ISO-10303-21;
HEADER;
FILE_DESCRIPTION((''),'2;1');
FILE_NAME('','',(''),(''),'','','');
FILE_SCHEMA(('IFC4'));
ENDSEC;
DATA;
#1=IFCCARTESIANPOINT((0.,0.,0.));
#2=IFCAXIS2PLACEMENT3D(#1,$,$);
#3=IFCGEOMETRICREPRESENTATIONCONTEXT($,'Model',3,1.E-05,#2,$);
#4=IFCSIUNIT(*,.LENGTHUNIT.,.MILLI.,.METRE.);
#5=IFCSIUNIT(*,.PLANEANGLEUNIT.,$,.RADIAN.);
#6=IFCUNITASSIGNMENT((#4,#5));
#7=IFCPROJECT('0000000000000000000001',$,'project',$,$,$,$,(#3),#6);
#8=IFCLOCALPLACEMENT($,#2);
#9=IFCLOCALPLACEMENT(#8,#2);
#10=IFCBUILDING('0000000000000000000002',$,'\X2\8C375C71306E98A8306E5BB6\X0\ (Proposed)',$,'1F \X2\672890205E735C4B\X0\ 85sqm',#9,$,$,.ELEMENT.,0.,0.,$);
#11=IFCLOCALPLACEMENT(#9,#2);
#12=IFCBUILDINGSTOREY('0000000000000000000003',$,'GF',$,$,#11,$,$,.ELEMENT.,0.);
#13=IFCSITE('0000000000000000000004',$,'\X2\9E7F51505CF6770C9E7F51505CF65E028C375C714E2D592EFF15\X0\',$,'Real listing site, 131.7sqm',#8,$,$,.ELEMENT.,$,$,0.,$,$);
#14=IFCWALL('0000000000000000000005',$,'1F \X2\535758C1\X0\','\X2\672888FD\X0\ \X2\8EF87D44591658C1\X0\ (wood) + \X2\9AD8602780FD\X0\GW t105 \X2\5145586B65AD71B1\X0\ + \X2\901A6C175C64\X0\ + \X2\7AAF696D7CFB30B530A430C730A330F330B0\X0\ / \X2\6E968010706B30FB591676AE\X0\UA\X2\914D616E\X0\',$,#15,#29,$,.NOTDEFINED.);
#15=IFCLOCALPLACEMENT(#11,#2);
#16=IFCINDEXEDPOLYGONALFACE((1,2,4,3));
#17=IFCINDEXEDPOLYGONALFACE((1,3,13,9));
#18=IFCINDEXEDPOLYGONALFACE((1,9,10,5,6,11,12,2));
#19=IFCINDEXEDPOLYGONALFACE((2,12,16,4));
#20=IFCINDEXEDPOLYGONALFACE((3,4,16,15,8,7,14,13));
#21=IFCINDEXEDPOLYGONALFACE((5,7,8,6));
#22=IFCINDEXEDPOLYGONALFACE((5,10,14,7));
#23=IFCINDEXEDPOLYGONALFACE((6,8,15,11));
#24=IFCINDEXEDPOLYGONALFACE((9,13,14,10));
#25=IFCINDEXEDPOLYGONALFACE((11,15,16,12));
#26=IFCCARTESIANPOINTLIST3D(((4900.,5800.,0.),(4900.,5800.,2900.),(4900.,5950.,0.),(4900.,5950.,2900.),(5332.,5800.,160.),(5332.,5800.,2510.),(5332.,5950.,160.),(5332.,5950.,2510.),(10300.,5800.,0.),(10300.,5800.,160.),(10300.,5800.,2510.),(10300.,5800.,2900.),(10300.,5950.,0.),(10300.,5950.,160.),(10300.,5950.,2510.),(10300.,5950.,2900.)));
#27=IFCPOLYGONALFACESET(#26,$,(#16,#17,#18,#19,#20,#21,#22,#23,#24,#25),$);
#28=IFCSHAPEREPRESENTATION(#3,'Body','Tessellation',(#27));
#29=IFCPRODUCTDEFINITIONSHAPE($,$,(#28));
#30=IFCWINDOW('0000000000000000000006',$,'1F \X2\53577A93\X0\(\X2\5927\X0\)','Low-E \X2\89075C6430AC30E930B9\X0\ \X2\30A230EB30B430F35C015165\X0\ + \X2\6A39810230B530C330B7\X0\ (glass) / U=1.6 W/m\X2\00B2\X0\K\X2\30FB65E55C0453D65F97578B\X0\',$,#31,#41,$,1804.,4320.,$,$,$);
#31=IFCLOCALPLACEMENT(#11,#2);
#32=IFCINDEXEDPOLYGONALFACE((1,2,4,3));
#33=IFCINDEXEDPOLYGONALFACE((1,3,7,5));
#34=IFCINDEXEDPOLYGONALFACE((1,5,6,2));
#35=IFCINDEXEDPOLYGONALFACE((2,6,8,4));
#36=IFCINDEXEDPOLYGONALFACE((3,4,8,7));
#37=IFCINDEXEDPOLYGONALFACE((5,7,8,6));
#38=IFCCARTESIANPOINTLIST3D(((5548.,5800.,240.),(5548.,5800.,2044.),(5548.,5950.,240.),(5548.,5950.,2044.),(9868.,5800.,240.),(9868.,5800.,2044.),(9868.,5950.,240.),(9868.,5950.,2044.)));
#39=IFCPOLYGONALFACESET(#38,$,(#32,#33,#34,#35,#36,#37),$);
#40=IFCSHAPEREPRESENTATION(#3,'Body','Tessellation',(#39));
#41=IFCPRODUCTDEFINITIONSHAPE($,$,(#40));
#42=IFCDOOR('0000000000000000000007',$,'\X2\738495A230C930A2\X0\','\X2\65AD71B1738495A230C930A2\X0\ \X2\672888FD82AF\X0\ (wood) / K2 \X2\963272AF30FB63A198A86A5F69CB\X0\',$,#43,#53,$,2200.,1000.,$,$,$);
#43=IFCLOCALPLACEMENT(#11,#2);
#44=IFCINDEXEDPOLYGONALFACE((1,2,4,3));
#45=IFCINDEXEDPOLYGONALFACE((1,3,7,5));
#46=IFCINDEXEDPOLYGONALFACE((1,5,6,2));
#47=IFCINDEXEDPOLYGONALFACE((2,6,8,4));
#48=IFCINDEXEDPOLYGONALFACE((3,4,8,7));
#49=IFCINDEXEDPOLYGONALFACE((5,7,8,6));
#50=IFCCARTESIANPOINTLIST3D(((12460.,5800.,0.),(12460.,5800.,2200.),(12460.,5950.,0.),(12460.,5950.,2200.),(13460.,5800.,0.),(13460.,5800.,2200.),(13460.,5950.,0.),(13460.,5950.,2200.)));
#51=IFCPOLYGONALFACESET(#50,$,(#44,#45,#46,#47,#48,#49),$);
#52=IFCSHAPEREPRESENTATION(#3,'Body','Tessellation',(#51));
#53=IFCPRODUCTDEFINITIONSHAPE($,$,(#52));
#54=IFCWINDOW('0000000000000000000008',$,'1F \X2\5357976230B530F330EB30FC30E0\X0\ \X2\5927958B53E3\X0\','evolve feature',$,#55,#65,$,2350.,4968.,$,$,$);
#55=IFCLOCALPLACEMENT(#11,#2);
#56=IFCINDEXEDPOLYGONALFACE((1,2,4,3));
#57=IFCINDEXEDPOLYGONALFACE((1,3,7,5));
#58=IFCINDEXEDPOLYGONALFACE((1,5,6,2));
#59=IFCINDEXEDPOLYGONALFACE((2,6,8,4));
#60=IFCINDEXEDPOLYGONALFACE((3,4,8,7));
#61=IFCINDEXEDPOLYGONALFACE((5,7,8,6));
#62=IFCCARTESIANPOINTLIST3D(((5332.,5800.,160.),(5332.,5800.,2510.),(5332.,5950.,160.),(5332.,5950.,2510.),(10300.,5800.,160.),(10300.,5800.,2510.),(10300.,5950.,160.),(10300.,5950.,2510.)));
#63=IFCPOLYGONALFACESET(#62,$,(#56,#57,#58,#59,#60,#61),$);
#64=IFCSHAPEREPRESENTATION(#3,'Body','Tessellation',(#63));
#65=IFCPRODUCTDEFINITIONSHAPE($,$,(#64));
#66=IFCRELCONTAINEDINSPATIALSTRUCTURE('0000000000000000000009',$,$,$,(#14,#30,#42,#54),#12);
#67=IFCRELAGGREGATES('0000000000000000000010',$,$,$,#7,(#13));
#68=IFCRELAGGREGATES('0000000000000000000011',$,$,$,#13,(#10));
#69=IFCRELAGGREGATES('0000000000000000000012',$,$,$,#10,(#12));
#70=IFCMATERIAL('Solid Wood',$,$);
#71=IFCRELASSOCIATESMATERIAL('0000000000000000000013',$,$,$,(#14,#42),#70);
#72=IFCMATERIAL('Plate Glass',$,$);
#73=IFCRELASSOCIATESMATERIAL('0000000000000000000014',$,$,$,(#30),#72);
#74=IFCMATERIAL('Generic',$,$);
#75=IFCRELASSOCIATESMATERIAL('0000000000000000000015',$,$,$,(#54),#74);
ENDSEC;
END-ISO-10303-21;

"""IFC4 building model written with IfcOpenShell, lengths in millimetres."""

from ifc_helpers import new_model, si_unit, frame, frame_2d, origin, place, context, project, spatial, rectangle, extrude, material, element, fill, save


model = new_model("IFC4")

# Units and contexts
model_context = context("Model", 3, precision=1e-05, world=origin())
ifc_project = project(units=[si_unit("LENGTHUNIT", "METRE", prefix="MILLI"), si_unit("PLANEANGLEUNIT", "RADIAN")], contexts=[model_context])

# Site, building, storey
site_placement = place(None, origin())
site = spatial("IfcSite", under=ifc_project, at=site_placement, Name="鹿児島県鹿児島市谷山中央５", ObjectType="Real listing site, 131.7sqm", CompositionType="ELEMENT", RefElevation=0.0)
building_placement = place(site_placement, origin())
building = spatial("IfcBuilding", under=site, at=building_placement, Name="谷山の風の家 (Proposed)", ObjectType="1F 木造平屋 85sqm", CompositionType="ELEMENT", ElevationOfRefHeight=0.0, ElevationOfTerrain=0.0)
storey_placement = place(building_placement, origin())
storey = spatial("IfcBuildingStorey", under=building, at=storey_placement, Name="GF", CompositionType="ELEMENT", Elevation=0.0)

# Shared definitions
ifc_material_1 = material(Name="Solid Wood")
ifc_material_2 = material(Name="Generic")

# Wall, openings, windows, door
wall_1_placement = place(storey_placement, frame((2450.0, 2900.0, 0.0)))
wall_1 = element("IfcWall", 1, at=wall_1_placement, inside=storey, material=ifc_material_1, Name="1F 南壁", Description="木製 軸組外壁 (wood) + 高性能GW t105 充填断熱 + 通気層 + 窯業系サイディング / 準耐火・外皮UA配慮", PredefinedType="NOTDEFINED", context=model_context, shape_type="SweptSolid", body=[
    extrude(rectangle(XDim=5400.0, YDim=150.0, at=frame_2d((2700.0, 75.0))), frame((2450.0, 2900.0, 0.0)), (0.0, 0.0, 1.0), 2900.0),
])
opening_1_placement = place(storey_placement, frame((2774.0, 2900.0, 120.0)))
opening_1 = element("IfcOpeningElement", 2, at=opening_1_placement, cuts=wall_1, PredefinedType="NOTDEFINED", context=model_context, shape_type="SweptSolid", body=[
    extrude(rectangle(XDim=4320.0, YDim=150.0, at=frame_2d((2160.0, 75.0))), frame((2774.0, 2900.0, 120.0)), (0.0, 0.0, 1.0), 1804.0),
])
opening_2_placement = place(storey_placement, frame((6230.0, 2900.0, 0.0)))
opening_2 = element("IfcOpeningElement", 3, at=opening_2_placement, cuts=wall_1, PredefinedType="NOTDEFINED", context=model_context, shape_type="SweptSolid", body=[
    extrude(rectangle(XDim=1000.0, YDim=150.0, at=frame_2d((500.0, 75.0))), frame((6230.0, 2900.0, 0.0)), (0.0, 0.0, 1.0), 2200.0),
])
opening_3_placement = place(storey_placement, frame((2666.0, 2900.0, 80.0)))
opening_3 = element("IfcOpeningElement", 4, at=opening_3_placement, cuts=wall_1, PredefinedType="NOTDEFINED", context=model_context, shape_type="SweptSolid", body=[
    extrude(rectangle(XDim=4968.0, YDim=150.0, at=frame_2d((2484.0, 75.0))), frame((2666.0, 2900.0, 80.0)), (0.0, 0.0, 1.0), 2350.0),
])
ifc_material_3 = material(Name="Plate Glass")
window_1_placement = place(storey_placement, frame((2774.0, 2900.0, 120.0)))
window_1 = element("IfcWindow", 5, at=window_1_placement, inside=storey, material=ifc_material_3, Name="1F 南窓(大)", Description="Low-E 複層ガラス アルゴン封入 + 樹脂サッシ (glass) / U=1.6 W/m²K・日射取得型", OverallHeight=1804.0, OverallWidth=4320.0, context=model_context, shape_type="SweptSolid", body=[
    extrude(rectangle(XDim=4320.0, YDim=150.0, at=frame_2d((2160.0, 75.0))), frame((2774.0, 2900.0, 120.0)), (0.0, 0.0, 1.0), 1804.0),
])
fill(opening_1, window_1)
door_1_placement = place(storey_placement, frame((6230.0, 2900.0, 0.0)))
door_1 = element("IfcDoor", 6, at=door_1_placement, inside=storey, material=ifc_material_1, Name="玄関ドア", Description="断熱玄関ドア 木製芯 (wood) / K2 防犯・採風機構", OverallHeight=2200.0, OverallWidth=1000.0, context=model_context, shape_type="SweptSolid", body=[
    extrude(rectangle(XDim=1000.0, YDim=150.0, at=frame_2d((500.0, 75.0))), frame((6230.0, 2900.0, 0.0)), (0.0, 0.0, 1.0), 2200.0),
])
fill(opening_2, door_1)
window_2_placement = place(storey_placement, frame((2666.0, 2900.0, 80.0)))
window_2 = element("IfcWindow", 7, at=window_2_placement, inside=storey, material=ifc_material_2, Name="1F 南面サンルーム 大開口", Description="evolve feature", OverallHeight=2350.0, OverallWidth=4968.0, context=model_context, shape_type="SweptSolid", body=[
    extrude(rectangle(XDim=4968.0, YDim=150.0, at=frame_2d((2484.0, 75.0))), frame((2666.0, 2900.0, 80.0)), (0.0, 0.0, 1.0), 2350.0),
])
fill(opening_3, window_2)

save(model, "model.ifc")
